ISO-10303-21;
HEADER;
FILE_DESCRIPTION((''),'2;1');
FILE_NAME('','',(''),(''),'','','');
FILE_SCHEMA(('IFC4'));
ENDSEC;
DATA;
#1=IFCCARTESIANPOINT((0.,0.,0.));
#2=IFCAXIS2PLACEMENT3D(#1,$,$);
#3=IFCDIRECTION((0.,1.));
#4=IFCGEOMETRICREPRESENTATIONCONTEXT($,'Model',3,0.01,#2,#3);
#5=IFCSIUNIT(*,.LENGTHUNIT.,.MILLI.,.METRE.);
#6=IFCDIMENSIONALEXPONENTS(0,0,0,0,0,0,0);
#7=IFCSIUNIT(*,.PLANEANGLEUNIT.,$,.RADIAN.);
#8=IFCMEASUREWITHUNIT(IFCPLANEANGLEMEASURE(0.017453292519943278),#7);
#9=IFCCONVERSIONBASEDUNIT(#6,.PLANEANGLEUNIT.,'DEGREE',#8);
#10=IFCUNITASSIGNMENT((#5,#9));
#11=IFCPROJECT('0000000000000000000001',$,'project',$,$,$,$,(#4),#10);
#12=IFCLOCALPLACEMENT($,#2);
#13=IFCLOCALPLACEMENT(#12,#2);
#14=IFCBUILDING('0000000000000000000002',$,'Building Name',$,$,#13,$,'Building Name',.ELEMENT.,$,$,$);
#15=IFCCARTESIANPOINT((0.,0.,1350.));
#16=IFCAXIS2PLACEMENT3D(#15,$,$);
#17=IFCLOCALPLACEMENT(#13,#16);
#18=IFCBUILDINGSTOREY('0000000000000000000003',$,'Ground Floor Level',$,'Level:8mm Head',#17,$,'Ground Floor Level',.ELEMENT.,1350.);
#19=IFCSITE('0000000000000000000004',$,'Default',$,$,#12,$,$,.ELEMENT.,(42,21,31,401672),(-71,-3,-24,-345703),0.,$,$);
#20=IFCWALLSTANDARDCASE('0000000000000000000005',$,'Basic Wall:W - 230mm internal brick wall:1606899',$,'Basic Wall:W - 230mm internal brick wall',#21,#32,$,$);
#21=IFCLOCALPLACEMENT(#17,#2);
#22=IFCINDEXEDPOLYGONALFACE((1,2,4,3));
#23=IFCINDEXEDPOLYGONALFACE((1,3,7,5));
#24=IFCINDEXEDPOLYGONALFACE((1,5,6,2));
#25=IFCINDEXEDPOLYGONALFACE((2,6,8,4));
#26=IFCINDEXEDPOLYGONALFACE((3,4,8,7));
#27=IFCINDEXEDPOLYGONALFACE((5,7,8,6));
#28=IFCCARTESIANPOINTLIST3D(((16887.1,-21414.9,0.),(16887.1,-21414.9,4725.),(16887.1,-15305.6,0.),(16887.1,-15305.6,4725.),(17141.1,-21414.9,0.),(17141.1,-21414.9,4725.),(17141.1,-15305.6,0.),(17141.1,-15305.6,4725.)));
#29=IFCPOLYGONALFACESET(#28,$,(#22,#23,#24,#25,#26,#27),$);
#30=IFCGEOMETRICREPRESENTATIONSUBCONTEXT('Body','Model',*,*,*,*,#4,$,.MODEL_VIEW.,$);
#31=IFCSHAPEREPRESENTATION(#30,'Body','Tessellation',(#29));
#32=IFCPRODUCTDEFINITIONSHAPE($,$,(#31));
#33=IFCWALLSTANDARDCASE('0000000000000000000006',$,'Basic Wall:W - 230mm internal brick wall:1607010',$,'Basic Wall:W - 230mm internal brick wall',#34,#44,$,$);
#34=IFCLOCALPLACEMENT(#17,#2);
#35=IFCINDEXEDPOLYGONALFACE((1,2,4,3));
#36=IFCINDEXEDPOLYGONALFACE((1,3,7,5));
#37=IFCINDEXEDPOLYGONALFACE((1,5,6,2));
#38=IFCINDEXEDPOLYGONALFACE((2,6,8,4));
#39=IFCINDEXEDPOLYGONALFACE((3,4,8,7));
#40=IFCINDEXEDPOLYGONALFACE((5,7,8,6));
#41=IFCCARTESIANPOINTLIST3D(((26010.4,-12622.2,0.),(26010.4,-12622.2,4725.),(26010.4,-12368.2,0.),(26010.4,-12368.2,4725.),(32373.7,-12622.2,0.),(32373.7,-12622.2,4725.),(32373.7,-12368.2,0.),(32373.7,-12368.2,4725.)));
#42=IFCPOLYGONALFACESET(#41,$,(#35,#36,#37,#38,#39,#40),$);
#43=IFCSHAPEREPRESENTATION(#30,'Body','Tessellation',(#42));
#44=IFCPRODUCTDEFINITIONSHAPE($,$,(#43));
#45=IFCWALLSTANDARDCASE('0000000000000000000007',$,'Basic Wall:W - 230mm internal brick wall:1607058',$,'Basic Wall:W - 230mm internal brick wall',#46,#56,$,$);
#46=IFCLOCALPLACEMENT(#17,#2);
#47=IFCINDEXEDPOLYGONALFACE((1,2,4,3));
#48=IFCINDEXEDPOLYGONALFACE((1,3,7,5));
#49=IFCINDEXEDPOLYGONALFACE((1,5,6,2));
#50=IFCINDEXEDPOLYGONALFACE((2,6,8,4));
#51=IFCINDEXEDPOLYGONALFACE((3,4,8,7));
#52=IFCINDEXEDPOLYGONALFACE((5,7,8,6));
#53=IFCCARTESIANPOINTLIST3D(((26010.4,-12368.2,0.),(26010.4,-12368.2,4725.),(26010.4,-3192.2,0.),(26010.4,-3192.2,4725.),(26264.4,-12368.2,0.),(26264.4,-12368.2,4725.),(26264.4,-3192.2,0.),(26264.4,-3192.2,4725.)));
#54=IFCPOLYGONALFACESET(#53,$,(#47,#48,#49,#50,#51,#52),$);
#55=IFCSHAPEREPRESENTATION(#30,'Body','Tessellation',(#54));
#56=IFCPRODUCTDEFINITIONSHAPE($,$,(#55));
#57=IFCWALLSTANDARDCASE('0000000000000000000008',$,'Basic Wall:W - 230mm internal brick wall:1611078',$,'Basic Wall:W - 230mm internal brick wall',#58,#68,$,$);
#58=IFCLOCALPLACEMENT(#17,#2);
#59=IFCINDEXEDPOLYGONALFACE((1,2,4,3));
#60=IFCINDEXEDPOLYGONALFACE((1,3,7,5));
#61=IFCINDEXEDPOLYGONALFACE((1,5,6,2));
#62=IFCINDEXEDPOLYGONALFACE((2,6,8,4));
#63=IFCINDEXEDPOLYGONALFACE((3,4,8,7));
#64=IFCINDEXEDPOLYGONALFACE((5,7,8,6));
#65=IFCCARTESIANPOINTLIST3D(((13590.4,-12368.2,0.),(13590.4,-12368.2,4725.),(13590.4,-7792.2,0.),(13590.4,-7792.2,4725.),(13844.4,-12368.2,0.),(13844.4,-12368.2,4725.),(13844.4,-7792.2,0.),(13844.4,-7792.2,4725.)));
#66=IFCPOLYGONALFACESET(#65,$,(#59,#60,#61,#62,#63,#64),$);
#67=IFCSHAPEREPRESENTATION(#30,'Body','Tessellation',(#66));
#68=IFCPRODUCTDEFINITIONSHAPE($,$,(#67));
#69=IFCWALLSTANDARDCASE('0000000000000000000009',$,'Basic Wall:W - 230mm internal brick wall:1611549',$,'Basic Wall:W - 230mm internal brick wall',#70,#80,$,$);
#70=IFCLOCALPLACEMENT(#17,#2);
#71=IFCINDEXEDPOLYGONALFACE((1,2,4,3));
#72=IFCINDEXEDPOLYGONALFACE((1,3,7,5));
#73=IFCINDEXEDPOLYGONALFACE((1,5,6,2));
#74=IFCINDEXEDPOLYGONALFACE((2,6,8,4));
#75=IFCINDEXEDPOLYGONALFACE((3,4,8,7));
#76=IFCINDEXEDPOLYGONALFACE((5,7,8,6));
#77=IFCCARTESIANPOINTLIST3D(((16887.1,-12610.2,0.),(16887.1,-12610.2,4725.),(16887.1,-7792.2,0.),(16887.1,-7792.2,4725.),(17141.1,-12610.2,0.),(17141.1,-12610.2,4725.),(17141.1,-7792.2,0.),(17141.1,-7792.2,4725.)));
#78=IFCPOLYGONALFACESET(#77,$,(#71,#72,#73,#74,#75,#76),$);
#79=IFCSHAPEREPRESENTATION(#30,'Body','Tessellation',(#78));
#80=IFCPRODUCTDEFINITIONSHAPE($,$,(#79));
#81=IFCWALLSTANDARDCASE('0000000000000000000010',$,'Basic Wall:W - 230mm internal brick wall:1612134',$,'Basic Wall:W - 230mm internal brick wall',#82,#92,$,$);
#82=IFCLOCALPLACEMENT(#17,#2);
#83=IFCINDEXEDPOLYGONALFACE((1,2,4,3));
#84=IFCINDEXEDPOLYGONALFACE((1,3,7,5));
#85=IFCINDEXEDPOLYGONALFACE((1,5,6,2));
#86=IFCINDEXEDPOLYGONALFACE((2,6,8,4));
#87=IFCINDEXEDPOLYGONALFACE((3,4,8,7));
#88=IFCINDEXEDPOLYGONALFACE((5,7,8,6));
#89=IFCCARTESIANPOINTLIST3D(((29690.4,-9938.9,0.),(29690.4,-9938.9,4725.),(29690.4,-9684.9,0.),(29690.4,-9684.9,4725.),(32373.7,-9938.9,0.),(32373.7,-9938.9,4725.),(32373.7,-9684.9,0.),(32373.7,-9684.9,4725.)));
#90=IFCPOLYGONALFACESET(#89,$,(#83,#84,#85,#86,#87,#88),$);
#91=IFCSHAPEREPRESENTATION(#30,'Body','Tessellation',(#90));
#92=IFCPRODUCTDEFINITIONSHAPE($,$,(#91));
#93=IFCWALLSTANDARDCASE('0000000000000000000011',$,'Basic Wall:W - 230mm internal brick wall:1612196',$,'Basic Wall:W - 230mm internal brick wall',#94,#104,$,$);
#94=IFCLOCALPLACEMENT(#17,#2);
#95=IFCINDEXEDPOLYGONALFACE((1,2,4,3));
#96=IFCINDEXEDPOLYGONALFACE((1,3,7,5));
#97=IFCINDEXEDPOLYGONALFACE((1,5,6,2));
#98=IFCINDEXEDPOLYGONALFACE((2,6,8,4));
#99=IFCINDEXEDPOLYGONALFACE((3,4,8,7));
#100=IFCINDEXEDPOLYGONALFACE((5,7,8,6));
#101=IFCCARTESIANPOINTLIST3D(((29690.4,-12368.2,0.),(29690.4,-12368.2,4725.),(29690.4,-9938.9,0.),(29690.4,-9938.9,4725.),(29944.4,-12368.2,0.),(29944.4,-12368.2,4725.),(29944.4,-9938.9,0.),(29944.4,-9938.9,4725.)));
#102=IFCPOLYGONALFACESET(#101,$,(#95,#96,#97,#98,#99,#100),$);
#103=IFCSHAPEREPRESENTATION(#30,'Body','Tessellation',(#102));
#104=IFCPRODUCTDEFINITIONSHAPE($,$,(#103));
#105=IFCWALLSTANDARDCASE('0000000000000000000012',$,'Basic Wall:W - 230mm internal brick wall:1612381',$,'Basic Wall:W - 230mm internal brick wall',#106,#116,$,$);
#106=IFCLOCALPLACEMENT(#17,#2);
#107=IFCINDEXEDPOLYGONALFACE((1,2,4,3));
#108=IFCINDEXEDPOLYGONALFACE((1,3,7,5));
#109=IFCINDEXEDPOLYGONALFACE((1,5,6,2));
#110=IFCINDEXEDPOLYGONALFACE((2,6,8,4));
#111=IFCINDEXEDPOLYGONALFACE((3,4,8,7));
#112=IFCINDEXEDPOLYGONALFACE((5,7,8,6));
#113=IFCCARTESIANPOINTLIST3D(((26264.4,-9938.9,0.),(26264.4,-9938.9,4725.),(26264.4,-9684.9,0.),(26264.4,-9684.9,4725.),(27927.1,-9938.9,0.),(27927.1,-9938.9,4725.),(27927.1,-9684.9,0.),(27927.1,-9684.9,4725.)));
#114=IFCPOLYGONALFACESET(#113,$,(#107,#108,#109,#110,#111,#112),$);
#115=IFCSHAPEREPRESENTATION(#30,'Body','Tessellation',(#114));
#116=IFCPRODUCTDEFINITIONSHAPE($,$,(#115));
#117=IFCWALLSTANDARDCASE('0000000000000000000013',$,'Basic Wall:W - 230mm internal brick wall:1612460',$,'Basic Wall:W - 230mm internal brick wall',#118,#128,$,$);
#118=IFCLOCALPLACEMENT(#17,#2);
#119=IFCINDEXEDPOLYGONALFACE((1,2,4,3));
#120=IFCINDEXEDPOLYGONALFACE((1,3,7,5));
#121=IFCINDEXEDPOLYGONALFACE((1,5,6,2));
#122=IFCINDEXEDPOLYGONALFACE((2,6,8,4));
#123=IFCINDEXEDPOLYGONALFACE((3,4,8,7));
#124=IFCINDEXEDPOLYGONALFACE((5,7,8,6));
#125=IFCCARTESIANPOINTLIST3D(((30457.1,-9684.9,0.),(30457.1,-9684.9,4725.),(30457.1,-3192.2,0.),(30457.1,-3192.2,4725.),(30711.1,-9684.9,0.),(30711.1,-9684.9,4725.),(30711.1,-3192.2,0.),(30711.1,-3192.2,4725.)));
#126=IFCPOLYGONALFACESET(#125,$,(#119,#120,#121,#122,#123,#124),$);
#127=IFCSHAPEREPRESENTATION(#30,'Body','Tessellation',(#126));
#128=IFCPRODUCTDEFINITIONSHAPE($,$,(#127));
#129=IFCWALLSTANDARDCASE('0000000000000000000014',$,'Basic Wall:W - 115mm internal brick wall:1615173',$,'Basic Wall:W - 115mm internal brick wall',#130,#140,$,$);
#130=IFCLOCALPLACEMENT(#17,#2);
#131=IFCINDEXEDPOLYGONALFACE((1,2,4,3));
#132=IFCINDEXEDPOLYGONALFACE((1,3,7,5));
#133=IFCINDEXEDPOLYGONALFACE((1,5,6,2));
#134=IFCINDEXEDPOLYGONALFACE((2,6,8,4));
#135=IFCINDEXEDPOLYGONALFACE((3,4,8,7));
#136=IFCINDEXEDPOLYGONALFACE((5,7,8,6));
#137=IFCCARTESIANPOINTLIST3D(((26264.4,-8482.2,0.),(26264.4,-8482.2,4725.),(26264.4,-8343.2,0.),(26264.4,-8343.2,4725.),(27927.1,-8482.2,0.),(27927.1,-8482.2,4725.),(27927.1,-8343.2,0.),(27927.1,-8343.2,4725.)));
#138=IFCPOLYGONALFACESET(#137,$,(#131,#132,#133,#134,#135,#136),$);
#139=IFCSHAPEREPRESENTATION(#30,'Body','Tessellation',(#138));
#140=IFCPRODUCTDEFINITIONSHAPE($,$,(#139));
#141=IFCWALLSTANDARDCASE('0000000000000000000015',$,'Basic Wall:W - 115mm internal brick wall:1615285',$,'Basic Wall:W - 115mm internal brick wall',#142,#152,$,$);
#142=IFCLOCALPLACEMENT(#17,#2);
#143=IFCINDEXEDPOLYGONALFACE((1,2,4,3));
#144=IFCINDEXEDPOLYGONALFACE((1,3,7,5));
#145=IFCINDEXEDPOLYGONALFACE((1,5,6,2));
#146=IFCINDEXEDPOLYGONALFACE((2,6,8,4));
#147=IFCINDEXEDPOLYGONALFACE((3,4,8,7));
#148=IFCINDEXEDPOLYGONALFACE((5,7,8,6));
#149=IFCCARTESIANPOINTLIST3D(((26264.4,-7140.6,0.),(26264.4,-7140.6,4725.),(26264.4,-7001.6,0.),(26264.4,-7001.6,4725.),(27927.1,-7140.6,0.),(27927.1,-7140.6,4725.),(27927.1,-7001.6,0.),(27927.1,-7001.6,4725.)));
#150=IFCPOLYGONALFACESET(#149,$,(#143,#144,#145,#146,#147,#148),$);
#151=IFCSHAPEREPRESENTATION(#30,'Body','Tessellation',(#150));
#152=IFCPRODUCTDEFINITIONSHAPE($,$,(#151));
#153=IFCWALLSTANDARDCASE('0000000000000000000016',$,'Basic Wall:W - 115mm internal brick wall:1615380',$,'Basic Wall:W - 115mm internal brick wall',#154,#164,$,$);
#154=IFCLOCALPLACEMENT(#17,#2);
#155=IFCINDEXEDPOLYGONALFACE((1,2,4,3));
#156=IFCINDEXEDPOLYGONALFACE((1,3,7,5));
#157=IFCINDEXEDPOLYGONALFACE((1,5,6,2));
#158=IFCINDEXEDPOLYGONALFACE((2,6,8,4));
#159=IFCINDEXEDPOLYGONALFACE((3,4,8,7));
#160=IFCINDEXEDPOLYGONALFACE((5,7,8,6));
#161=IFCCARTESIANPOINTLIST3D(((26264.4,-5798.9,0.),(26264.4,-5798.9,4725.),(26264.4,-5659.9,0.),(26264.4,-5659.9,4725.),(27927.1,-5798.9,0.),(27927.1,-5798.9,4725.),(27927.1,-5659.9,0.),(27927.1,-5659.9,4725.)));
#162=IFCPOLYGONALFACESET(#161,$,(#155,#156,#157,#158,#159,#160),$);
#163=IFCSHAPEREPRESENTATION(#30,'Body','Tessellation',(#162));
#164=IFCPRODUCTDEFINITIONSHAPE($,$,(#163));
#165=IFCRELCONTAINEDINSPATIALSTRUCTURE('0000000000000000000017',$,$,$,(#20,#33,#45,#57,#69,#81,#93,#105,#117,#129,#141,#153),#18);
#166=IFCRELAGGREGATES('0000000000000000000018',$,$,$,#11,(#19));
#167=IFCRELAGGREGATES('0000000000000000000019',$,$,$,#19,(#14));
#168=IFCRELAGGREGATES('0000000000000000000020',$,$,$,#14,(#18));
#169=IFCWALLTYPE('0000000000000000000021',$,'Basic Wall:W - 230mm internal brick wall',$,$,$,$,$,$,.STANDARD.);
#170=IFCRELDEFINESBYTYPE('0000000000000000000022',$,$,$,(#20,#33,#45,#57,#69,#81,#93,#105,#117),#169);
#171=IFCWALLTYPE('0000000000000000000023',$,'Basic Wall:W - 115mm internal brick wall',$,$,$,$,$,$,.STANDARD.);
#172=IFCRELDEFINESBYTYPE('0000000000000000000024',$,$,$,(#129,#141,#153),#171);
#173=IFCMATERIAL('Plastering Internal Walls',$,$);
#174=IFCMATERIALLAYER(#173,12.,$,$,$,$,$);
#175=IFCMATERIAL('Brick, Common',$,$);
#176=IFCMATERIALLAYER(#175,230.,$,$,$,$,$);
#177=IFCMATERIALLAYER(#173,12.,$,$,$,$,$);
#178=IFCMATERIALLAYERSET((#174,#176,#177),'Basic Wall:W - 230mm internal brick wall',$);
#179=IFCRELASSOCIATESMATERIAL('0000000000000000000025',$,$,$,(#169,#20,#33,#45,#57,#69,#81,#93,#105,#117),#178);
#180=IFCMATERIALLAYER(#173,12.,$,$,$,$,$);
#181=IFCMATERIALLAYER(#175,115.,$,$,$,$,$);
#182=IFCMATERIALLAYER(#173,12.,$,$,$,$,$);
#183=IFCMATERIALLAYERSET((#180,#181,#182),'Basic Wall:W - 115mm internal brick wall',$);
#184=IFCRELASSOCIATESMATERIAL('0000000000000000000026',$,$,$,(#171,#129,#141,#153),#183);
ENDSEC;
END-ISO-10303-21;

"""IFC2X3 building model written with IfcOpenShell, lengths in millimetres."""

from ifc_helpers import new_model, entity, si_unit, converted_unit, direction, frame, frame_2d, origin, place, context, subcontext, project, spatial, rectangle, extrude, material, layer, layer_set, layer_usage, type_object, element, save


model = new_model("IFC2X3")

# Units and contexts
model_context = context("Model", 3, precision=0.01, world=origin(), true_north=direction((0.0, 1.0)))
body_context = subcontext(model_context, "Body", "Model", "MODEL_VIEW")
ifc_project = project(units=[si_unit("LENGTHUNIT", "METRE", prefix="MILLI"), converted_unit("PLANEANGLEUNIT", "DEGREE", entity("IfcPlaneAngleMeasure", 0.017453292519943278), si_unit("PLANEANGLEUNIT", "RADIAN"), dimensions=[0, 0, 0, 0, 0, 0, 0])], contexts=[model_context])

# Site, building, storey
site_placement = place(None, origin())
site = spatial("IfcSite", under=ifc_project, at=site_placement, Name="Default", CompositionType="ELEMENT", RefLatitude=(42, 21, 31, 401672), RefLongitude=(-71, -3, -24, -345703), RefElevation=0.0)
building_placement = place(site_placement, origin())
building = spatial("IfcBuilding", under=site, at=building_placement, Name="Building Name", LongName="Building Name", CompositionType="ELEMENT")
storey_placement = place(building_placement, frame((0.0, 0.0, 1350.0)))
storey = spatial("IfcBuildingStorey", under=building, at=storey_placement, Name="Ground Floor Level", ObjectType="Level:8mm Head", LongName="Ground Floor Level", CompositionType="ELEMENT", Elevation=1350.0)

# Walls
ifc_material_1 = material(Name="Brick, Common")
ifc_material_2 = material(Name="Plastering Internal Walls")
ifc_layer_1 = layer(ifc_material_2, 12.0)
ifc_layer_2 = layer(ifc_material_1, 230.0)
ifc_layer_3 = layer(ifc_material_2, 12.0)
ifc_layer_set_1 = layer_set([ifc_layer_1, ifc_layer_2, ifc_layer_3], Name="Basic Wall:W - 230mm internal brick wall")
wall_type_1 = type_object("IfcWallType", Name="Basic Wall:W - 230mm internal brick wall", PredefinedType="STANDARD", material=ifc_layer_set_1)
ifc_layer_usage_1 = layer_usage(ifc_layer_set_1, "AXIS2", "NEGATIVE", 127.0)
wall_1_placement = place(storey_placement, frame((17014.1, -21414.9, 0.0), z_axis=(0.0, 0.0, 1.0), x_axis=(0.0, 1.0, 0.0)))
element("IfcWallStandardCase", 1, at=wall_1_placement, inside=storey, type_object=wall_type_1, material=ifc_layer_usage_1, Name="Basic Wall:W - 230mm internal brick wall:1606899", ObjectType="Basic Wall:W - 230mm internal brick wall", context=body_context, shape_type="SweptSolid", body=[
    extrude(rectangle(XDim=6109.3, YDim=254.0, at=frame_2d((3054.7, 0.0), x_axis=(-1.0, 0.0))), origin(), (0.0, 0.0, 1.0), 4725.0),
])
ifc_layer_usage_2 = layer_usage(ifc_layer_set_1, "AXIS2", "NEGATIVE", 127.0)
wall_2_placement = place(storey_placement, frame((32373.7, -12495.2, 0.0), z_axis=(0.0, 0.0, 1.0), x_axis=(-1.0, 0.0, 0.0)))
element("IfcWallStandardCase", 2, at=wall_2_placement, inside=storey, type_object=wall_type_1, material=ifc_layer_usage_2, Name="Basic Wall:W - 230mm internal brick wall:1607010", ObjectType="Basic Wall:W - 230mm internal brick wall", context=body_context, shape_type="SweptSolid", body=[
    extrude(rectangle(XDim=6363.3, YDim=254.0, at=frame_2d((3181.7, 0.0), x_axis=(-1.0, 0.0))), origin(), (0.0, 0.0, 1.0), 4725.0),
])
ifc_layer_usage_3 = layer_usage(ifc_layer_set_1, "AXIS2", "NEGATIVE", 127.0)
wall_3_placement = place(storey_placement, frame((26137.4, -12368.2, 0.0), z_axis=(0.0, 0.0, 1.0), x_axis=(0.0, 1.0, 0.0)))
element("IfcWallStandardCase", 3, at=wall_3_placement, inside=storey, type_object=wall_type_1, material=ifc_layer_usage_3, Name="Basic Wall:W - 230mm internal brick wall:1607058", ObjectType="Basic Wall:W - 230mm internal brick wall", context=body_context, shape_type="SweptSolid", body=[
    extrude(rectangle(XDim=9176.0, YDim=254.0, at=frame_2d((4588.0, 0.0), x_axis=(-1.0, 0.0))), origin(), (0.0, 0.0, 1.0), 4725.0),
])
ifc_layer_usage_4 = layer_usage(ifc_layer_set_1, "AXIS2", "NEGATIVE", 127.0)
wall_4_placement = place(storey_placement, frame((13717.4, -12368.2, 0.0), z_axis=(0.0, 0.0, 1.0), x_axis=(0.0, 1.0, 0.0)))
element("IfcWallStandardCase", 4, at=wall_4_placement, inside=storey, type_object=wall_type_1, material=ifc_layer_usage_4, Name="Basic Wall:W - 230mm internal brick wall:1611078", ObjectType="Basic Wall:W - 230mm internal brick wall", context=body_context, shape_type="SweptSolid", body=[
    extrude(rectangle(XDim=4576.0, YDim=254.0, at=frame_2d((2288.0, 0.0), x_axis=(-1.0, 0.0))), origin(), (0.0, 0.0, 1.0), 4725.0),
])
ifc_layer_usage_5 = layer_usage(ifc_layer_set_1, "AXIS2", "NEGATIVE", 127.0)
wall_5_placement = place(storey_placement, frame((17014.1, -12610.2, 0.0), z_axis=(0.0, 0.0, 1.0), x_axis=(0.0, 1.0, 0.0)))
element("IfcWallStandardCase", 5, at=wall_5_placement, inside=storey, type_object=wall_type_1, material=ifc_layer_usage_5, Name="Basic Wall:W - 230mm internal brick wall:1611549", ObjectType="Basic Wall:W - 230mm internal brick wall", context=body_context, shape_type="SweptSolid", body=[
    extrude(rectangle(XDim=4818.0, YDim=254.0, at=frame_2d((2409.0, 0.0), x_axis=(-1.0, 0.0))), origin(), (0.0, 0.0, 1.0), 4725.0),
])
ifc_layer_usage_6 = layer_usage(ifc_layer_set_1, "AXIS2", "NEGATIVE", 127.0)
wall_6_placement = place(storey_placement, frame((32373.7, -9811.9, 0.0), z_axis=(0.0, 0.0, 1.0), x_axis=(-1.0, 0.0, 0.0)))
element("IfcWallStandardCase", 6, at=wall_6_placement, inside=storey, type_object=wall_type_1, material=ifc_layer_usage_6, Name="Basic Wall:W - 230mm internal brick wall:1612134", ObjectType="Basic Wall:W - 230mm internal brick wall", context=body_context, shape_type="SweptSolid", body=[
    extrude(rectangle(XDim=2683.3, YDim=254.0, at=frame_2d((1341.7, 0.0), x_axis=(-1.0, 0.0))), origin(), (0.0, 0.0, 1.0), 4725.0),
])
ifc_layer_usage_7 = layer_usage(ifc_layer_set_1, "AXIS2", "NEGATIVE", 127.0)
wall_7_placement = place(storey_placement, frame((29817.4, -9938.9, 0.0), z_axis=(0.0, 0.0, 1.0), x_axis=(0.0, -1.0, 0.0)))
element("IfcWallStandardCase", 7, at=wall_7_placement, inside=storey, type_object=wall_type_1, material=ifc_layer_usage_7, Name="Basic Wall:W - 230mm internal brick wall:1612196", ObjectType="Basic Wall:W - 230mm internal brick wall", context=body_context, shape_type="SweptSolid", body=[
    extrude(rectangle(XDim=2429.3, YDim=254.0, at=frame_2d((1214.7, 0.0), x_axis=(-1.0, 0.0))), origin(), (0.0, 0.0, 1.0), 4725.0),
])
ifc_layer_usage_8 = layer_usage(ifc_layer_set_1, "AXIS2", "NEGATIVE", 127.0)
wall_8_placement = place(storey_placement, frame((27927.1, -9811.9, 0.0), z_axis=(0.0, 0.0, 1.0), x_axis=(-1.0, 0.0, 0.0)))
element("IfcWallStandardCase", 8, at=wall_8_placement, inside=storey, type_object=wall_type_1, material=ifc_layer_usage_8, Name="Basic Wall:W - 230mm internal brick wall:1612381", ObjectType="Basic Wall:W - 230mm internal brick wall", context=body_context, shape_type="SweptSolid", body=[
    extrude(rectangle(XDim=1662.7, YDim=254.0, at=frame_2d((831.3, 0.0), x_axis=(-1.0, 0.0))), origin(), (0.0, 0.0, 1.0), 4725.0),
])
ifc_layer_usage_9 = layer_usage(ifc_layer_set_1, "AXIS2", "NEGATIVE", 127.0)
wall_9_placement = place(storey_placement, frame((30584.1, -9684.9, 0.0), z_axis=(0.0, 0.0, 1.0), x_axis=(0.0, 1.0, 0.0)))
element("IfcWallStandardCase", 9, at=wall_9_placement, inside=storey, type_object=wall_type_1, material=ifc_layer_usage_9, Name="Basic Wall:W - 230mm internal brick wall:1612460", ObjectType="Basic Wall:W - 230mm internal brick wall", context=body_context, shape_type="SweptSolid", body=[
    extrude(rectangle(XDim=6492.7, YDim=254.0, at=frame_2d((3246.3, 0.0), x_axis=(-1.0, 0.0))), origin(), (0.0, 0.0, 1.0), 4725.0),
])
ifc_layer_4 = layer(ifc_material_2, 12.0)
ifc_layer_5 = layer(ifc_material_1, 115.0)
ifc_layer_6 = layer(ifc_material_2, 12.0)
ifc_layer_set_2 = layer_set([ifc_layer_4, ifc_layer_5, ifc_layer_6], Name="Basic Wall:W - 115mm internal brick wall")
ifc_layer_usage_10 = layer_usage(ifc_layer_set_2, "AXIS2", "NEGATIVE", 69.5)
wall_type_2 = type_object("IfcWallType", Name="Basic Wall:W - 115mm internal brick wall", PredefinedType="STANDARD", material=ifc_layer_set_2)
wall_10_placement = place(storey_placement, frame((27927.1, -8412.7, 0.0), z_axis=(0.0, 0.0, 1.0), x_axis=(-1.0, 0.0, 0.0)))
element("IfcWallStandardCase", 10, at=wall_10_placement, inside=storey, type_object=wall_type_2, material=ifc_layer_usage_10, Name="Basic Wall:W - 115mm internal brick wall:1615173", ObjectType="Basic Wall:W - 115mm internal brick wall", context=body_context, shape_type="SweptSolid", body=[
    extrude(rectangle(XDim=1662.7, YDim=139.0, at=frame_2d((831.3, 0.0), x_axis=(-1.0, 0.0))), origin(), (0.0, 0.0, 1.0), 4725.0),
])
ifc_layer_usage_11 = layer_usage(ifc_layer_set_2, "AXIS2", "NEGATIVE", 69.5)
wall_11_placement = place(storey_placement, frame((27927.1, -7071.1, 0.0), z_axis=(0.0, 0.0, 1.0), x_axis=(-1.0, 0.0, 0.0)))
element("IfcWallStandardCase", 11, at=wall_11_placement, inside=storey, type_object=wall_type_2, material=ifc_layer_usage_11, Name="Basic Wall:W - 115mm internal brick wall:1615285", ObjectType="Basic Wall:W - 115mm internal brick wall", context=body_context, shape_type="SweptSolid", body=[
    extrude(rectangle(XDim=1662.7, YDim=139.0, at=frame_2d((831.3, 0.0), x_axis=(-1.0, 0.0))), origin(), (0.0, 0.0, 1.0), 4725.0),
])
ifc_layer_usage_12 = layer_usage(ifc_layer_set_2, "AXIS2", "NEGATIVE", 69.5)
wall_12_placement = place(storey_placement, frame((27927.1, -5729.4, 0.0), z_axis=(0.0, 0.0, 1.0), x_axis=(-1.0, 0.0, 0.0)))
element("IfcWallStandardCase", 12, at=wall_12_placement, inside=storey, type_object=wall_type_2, material=ifc_layer_usage_12, Name="Basic Wall:W - 115mm internal brick wall:1615380", ObjectType="Basic Wall:W - 115mm internal brick wall", context=body_context, shape_type="SweptSolid", body=[
    extrude(rectangle(XDim=1662.7, YDim=139.0, at=frame_2d((831.3, 0.0), x_axis=(-1.0, 0.0))), origin(), (0.0, 0.0, 1.0), 4725.0),
])

save(model, "model.ifc")
